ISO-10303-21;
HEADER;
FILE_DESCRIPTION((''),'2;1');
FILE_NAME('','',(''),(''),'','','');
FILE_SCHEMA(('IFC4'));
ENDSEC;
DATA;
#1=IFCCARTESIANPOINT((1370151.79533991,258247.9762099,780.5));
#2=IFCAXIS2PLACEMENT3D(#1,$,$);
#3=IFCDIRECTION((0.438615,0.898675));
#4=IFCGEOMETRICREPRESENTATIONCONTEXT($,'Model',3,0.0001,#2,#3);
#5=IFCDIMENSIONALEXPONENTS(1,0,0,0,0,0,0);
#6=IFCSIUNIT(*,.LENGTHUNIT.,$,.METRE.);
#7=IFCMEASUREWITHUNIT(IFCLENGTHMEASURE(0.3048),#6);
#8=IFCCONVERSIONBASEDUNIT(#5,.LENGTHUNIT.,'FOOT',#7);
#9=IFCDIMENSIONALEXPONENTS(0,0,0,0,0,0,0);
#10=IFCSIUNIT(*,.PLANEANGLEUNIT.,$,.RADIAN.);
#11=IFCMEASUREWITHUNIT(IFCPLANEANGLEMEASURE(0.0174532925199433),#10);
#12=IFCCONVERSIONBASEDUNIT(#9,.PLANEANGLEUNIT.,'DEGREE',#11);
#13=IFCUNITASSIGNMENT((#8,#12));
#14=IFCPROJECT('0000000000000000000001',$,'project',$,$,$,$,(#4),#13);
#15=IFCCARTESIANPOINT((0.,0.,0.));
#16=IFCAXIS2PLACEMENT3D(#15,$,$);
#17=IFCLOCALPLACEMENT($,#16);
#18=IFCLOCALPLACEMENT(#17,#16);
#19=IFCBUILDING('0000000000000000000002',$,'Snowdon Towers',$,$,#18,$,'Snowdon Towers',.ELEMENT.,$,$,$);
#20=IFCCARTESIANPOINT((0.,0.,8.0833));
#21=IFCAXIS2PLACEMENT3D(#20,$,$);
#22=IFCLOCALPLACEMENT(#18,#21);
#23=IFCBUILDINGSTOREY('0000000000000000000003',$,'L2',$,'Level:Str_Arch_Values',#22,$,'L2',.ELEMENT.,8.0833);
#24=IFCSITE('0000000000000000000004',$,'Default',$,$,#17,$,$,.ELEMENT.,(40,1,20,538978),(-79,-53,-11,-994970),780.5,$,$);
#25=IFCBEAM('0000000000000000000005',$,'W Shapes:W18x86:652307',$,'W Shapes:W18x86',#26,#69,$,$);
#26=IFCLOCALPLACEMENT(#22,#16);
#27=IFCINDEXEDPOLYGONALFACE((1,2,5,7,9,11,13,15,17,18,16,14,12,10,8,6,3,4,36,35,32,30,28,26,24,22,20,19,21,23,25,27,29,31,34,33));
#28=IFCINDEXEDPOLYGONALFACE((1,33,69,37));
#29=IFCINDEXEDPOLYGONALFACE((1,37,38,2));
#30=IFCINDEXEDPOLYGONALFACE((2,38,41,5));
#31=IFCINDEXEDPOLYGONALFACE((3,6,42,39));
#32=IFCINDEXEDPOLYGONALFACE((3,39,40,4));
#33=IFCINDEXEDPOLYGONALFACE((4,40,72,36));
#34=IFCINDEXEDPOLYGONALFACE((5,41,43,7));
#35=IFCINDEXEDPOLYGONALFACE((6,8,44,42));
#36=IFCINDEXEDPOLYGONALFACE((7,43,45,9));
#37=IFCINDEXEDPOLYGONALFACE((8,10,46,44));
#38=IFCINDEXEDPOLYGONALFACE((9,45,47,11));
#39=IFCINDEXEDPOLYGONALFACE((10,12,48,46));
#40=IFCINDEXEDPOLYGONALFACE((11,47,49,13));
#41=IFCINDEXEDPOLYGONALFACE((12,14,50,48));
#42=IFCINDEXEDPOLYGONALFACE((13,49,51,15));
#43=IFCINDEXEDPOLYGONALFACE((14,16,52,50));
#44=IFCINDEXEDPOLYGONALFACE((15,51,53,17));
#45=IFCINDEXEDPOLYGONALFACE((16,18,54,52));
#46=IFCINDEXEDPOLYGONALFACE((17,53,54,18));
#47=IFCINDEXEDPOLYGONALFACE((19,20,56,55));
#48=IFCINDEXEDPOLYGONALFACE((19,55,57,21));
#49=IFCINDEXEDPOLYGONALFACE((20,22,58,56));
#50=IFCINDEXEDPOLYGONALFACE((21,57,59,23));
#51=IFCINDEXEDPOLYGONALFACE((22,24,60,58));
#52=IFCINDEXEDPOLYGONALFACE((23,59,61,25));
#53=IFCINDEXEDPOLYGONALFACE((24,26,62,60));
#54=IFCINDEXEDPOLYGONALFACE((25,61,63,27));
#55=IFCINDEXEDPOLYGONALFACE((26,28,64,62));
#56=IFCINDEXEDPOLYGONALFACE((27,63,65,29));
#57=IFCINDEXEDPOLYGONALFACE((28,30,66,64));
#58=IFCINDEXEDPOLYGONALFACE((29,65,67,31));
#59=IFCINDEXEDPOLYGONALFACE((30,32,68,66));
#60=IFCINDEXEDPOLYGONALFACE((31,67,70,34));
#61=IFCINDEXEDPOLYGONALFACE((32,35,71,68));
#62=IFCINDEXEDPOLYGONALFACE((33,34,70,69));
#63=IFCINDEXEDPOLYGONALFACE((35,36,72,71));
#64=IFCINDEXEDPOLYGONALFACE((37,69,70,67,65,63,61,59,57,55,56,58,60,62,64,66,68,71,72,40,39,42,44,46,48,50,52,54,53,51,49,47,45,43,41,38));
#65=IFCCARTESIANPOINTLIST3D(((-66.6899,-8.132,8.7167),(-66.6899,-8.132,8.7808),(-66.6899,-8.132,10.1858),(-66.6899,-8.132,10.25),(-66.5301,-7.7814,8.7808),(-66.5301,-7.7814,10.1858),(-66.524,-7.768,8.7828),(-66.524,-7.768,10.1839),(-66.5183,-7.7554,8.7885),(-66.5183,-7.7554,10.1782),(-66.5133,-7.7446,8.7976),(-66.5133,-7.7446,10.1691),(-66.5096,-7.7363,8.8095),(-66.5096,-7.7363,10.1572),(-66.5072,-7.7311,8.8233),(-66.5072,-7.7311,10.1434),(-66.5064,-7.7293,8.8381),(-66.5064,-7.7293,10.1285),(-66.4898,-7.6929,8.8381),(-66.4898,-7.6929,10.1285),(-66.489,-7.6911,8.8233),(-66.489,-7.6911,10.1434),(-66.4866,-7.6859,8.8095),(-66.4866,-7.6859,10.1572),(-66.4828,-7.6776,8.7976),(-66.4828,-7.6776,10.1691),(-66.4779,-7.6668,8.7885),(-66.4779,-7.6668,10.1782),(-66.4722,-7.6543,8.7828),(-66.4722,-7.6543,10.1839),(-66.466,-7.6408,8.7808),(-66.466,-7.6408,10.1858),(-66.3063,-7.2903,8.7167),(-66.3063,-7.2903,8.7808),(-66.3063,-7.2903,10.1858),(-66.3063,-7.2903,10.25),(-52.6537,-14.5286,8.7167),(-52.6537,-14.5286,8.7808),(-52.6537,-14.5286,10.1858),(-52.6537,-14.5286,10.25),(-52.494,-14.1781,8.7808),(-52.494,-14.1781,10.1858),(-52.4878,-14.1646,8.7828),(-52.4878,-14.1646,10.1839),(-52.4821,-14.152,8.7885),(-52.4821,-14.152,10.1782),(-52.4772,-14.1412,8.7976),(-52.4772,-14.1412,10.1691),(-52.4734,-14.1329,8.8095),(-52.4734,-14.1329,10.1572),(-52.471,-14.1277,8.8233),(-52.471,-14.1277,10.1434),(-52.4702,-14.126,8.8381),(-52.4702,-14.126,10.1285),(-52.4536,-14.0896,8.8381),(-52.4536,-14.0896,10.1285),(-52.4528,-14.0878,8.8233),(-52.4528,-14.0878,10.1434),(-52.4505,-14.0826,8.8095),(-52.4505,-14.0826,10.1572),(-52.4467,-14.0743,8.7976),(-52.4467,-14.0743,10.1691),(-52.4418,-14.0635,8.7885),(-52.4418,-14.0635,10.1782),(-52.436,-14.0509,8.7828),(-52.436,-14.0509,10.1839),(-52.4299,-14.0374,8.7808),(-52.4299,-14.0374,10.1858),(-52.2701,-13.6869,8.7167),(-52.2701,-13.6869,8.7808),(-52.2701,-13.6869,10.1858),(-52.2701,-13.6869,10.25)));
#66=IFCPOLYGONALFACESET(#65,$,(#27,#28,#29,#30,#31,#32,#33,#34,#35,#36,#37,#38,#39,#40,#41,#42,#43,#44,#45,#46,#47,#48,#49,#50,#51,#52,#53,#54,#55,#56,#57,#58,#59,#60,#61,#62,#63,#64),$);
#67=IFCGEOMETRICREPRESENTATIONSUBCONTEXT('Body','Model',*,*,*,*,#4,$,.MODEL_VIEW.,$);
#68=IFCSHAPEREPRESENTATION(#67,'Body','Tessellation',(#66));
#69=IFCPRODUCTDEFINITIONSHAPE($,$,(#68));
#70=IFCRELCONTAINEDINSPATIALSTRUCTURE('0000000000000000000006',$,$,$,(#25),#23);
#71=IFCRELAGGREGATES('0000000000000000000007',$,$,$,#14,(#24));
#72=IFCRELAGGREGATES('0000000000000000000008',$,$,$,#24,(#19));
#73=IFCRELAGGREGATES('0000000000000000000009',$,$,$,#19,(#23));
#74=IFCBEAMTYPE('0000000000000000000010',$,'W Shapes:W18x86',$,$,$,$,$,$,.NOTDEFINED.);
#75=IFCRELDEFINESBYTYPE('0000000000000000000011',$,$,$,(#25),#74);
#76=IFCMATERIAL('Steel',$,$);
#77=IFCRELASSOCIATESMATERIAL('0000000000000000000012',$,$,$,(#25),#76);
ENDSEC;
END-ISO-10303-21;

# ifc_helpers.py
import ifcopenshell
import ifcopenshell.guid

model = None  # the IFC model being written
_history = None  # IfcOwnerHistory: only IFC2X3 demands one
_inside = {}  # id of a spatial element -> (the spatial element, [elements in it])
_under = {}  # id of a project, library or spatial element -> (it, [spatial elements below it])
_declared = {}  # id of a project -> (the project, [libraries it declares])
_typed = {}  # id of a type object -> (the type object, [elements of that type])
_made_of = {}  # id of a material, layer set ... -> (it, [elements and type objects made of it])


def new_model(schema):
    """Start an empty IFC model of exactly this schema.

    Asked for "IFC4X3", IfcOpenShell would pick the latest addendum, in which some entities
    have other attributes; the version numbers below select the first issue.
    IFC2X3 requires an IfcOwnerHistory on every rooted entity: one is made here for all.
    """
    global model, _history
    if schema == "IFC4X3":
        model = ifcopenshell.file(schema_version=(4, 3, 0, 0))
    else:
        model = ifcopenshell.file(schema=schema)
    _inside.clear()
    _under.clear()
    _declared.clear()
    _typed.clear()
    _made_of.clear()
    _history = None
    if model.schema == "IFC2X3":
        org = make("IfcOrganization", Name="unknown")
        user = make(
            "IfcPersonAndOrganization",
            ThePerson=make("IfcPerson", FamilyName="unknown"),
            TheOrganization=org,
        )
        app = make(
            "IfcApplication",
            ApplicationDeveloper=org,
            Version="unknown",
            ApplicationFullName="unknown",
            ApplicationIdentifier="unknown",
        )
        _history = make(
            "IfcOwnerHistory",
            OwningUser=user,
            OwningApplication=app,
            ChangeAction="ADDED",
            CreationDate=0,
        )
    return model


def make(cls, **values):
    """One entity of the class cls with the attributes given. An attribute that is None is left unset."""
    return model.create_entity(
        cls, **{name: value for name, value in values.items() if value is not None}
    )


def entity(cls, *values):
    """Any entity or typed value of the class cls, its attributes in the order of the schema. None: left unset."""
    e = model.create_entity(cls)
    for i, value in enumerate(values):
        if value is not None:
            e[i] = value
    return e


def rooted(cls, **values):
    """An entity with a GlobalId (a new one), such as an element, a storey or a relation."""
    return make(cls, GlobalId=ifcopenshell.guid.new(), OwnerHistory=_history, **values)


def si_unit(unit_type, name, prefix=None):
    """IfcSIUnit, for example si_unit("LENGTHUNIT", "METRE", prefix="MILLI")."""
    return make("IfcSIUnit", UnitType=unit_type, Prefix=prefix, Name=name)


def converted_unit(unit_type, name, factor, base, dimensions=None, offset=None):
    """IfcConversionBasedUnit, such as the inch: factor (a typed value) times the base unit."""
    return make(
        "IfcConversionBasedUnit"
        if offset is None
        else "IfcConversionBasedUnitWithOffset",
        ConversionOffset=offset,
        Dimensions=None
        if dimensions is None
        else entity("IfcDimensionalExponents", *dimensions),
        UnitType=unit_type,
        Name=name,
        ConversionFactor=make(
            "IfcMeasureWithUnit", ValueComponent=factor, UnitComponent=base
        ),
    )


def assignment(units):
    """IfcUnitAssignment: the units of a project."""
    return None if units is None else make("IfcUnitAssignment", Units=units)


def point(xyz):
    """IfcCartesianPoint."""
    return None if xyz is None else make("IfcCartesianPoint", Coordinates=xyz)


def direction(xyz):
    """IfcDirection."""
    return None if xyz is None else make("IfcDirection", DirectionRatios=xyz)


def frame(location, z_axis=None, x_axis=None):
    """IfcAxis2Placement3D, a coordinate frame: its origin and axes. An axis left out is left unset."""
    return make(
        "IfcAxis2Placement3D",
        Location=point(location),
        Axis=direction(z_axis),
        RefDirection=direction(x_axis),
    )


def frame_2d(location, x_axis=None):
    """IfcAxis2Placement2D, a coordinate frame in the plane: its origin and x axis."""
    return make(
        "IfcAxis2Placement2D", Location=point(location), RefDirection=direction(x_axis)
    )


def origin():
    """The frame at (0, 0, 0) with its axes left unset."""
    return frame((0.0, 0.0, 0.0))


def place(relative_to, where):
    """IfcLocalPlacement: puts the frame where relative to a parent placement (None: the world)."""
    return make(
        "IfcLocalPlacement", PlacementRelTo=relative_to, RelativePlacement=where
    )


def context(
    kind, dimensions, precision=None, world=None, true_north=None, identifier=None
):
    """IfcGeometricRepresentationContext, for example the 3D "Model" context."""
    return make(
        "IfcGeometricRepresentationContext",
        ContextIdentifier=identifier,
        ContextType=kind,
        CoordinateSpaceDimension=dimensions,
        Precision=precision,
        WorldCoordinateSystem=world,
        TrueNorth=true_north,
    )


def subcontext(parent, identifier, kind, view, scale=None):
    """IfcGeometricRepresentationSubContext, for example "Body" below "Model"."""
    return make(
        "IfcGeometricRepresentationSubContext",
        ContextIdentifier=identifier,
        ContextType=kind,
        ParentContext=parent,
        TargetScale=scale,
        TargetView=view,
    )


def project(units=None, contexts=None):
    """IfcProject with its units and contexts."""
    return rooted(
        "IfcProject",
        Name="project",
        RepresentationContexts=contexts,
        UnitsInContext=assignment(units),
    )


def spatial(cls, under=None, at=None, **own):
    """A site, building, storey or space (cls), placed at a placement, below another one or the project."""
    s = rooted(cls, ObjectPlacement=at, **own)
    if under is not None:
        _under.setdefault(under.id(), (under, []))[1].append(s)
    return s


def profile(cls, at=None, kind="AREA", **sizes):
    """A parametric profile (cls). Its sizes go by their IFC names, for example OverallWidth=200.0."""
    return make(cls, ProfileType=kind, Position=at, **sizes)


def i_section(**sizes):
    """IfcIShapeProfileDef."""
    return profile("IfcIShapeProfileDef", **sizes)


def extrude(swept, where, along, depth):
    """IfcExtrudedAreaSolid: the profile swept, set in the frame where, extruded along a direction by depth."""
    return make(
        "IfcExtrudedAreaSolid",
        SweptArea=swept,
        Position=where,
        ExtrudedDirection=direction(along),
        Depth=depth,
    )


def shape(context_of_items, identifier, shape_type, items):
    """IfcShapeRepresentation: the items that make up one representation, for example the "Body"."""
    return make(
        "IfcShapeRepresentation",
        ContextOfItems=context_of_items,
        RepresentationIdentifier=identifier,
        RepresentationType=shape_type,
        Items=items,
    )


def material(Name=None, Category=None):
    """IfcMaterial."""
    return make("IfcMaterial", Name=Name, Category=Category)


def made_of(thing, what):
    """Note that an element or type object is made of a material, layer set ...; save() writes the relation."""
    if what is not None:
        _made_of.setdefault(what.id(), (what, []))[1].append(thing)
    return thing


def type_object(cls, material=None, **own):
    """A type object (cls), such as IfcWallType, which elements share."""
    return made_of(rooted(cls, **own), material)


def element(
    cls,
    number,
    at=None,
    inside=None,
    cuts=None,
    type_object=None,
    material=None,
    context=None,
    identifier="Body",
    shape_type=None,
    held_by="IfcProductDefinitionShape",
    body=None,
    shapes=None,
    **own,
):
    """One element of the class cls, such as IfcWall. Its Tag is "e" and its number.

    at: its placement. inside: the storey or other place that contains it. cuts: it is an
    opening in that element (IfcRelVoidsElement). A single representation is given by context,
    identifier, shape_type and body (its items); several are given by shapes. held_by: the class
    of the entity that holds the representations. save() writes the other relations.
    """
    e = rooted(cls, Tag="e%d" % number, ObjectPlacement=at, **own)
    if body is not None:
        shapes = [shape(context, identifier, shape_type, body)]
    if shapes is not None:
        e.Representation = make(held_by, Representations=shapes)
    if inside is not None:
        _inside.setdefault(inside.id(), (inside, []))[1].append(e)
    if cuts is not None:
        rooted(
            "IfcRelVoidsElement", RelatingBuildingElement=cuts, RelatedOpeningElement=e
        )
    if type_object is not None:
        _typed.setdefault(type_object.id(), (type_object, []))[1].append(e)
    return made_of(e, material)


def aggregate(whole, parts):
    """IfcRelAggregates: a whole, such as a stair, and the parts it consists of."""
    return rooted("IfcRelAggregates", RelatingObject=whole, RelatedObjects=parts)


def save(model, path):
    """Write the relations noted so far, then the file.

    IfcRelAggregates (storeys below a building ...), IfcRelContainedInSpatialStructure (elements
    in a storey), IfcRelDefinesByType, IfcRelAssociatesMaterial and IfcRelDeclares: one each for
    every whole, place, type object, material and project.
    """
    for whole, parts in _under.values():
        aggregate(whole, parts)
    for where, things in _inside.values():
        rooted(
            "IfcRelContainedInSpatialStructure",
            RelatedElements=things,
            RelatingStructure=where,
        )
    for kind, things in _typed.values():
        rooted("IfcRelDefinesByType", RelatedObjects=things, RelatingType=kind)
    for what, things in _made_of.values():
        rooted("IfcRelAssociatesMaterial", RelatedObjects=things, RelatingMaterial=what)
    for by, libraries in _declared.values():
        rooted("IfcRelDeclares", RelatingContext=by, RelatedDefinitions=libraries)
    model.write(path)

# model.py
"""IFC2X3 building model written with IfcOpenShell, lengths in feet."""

from ifc_helpers import new_model, entity, si_unit, converted_unit, direction, frame, frame_2d, origin, place, context, subcontext, project, spatial, i_section, extrude, material, type_object, element, save


model = new_model("IFC2X3")

# Units and contexts
model_context = context("Model", 3, precision=0.0001, world=frame((1370151.79533991, 258247.9762099, 780.5)), true_north=direction((0.438615, 0.898675)))
body_context = subcontext(model_context, "Body", "Model", "MODEL_VIEW")
ifc_project = project(units=[converted_unit("LENGTHUNIT", "FOOT", entity("IfcLengthMeasure", 0.3048), si_unit("LENGTHUNIT", "METRE"), dimensions=[1, 0, 0, 0, 0, 0, 0]), converted_unit("PLANEANGLEUNIT", "DEGREE", entity("IfcPlaneAngleMeasure", 0.0174532925199433), si_unit("PLANEANGLEUNIT", "RADIAN"), dimensions=[0, 0, 0, 0, 0, 0, 0])], contexts=[model_context])

# Site, building, storey
site_placement = place(None, origin())
site = spatial("IfcSite", under=ifc_project, at=site_placement, Name="Default", CompositionType="ELEMENT", RefLatitude=(40, 1, 20, 538978), RefLongitude=(-79, -53, -11, -994970), RefElevation=780.5)
building_placement = place(site_placement, origin())
building = spatial("IfcBuilding", under=site, at=building_placement, Name="Snowdon Towers", LongName="Snowdon Towers", CompositionType="ELEMENT")
storey_placement = place(building_placement, frame((0.0, 0.0, 8.0833)))
storey = spatial("IfcBuildingStorey", under=building, at=storey_placement, Name="L2", ObjectType="Level:Str_Arch_Values", LongName="L2", CompositionType="ELEMENT", Elevation=8.0833)

# Shared definitions
ifc_material_1 = material(Name="Steel")

# Beam
beam_type_1 = type_object("IfcBeamType", Name="W Shapes:W18x86", PredefinedType="NOTDEFINED")
beam_1_placement = place(storey_placement, frame((-66.0772, -7.9029, 10.25), z_axis=(0.0, 0.0, 1.0), x_axis=(0.909961, -0.414693, 0.0)))
element("IfcBeam", 1, at=beam_1_placement, inside=storey, type_object=beam_type_1, material=ifc_material_1, Name="W Shapes:W18x86:652307", ObjectType="W Shapes:W18x86", context=body_context, shape_type="SweptSolid", body=[
    extrude(i_section(OverallWidth=0.925, OverallDepth=1.5333, WebThickness=0.04, FlangeThickness=0.0642, FilletRadius=0.0573, at=frame_2d((0.0, 0.0), x_axis=(0.0, 1.0))), frame((-0.4625, 0.0, -0.7667), z_axis=(1.0, 0.0, 0.0), x_axis=(0.0, 0.0, -1.0)), (0.0, 0.0, 1.0), 15.425),
])

save(model, "model.ifc")
